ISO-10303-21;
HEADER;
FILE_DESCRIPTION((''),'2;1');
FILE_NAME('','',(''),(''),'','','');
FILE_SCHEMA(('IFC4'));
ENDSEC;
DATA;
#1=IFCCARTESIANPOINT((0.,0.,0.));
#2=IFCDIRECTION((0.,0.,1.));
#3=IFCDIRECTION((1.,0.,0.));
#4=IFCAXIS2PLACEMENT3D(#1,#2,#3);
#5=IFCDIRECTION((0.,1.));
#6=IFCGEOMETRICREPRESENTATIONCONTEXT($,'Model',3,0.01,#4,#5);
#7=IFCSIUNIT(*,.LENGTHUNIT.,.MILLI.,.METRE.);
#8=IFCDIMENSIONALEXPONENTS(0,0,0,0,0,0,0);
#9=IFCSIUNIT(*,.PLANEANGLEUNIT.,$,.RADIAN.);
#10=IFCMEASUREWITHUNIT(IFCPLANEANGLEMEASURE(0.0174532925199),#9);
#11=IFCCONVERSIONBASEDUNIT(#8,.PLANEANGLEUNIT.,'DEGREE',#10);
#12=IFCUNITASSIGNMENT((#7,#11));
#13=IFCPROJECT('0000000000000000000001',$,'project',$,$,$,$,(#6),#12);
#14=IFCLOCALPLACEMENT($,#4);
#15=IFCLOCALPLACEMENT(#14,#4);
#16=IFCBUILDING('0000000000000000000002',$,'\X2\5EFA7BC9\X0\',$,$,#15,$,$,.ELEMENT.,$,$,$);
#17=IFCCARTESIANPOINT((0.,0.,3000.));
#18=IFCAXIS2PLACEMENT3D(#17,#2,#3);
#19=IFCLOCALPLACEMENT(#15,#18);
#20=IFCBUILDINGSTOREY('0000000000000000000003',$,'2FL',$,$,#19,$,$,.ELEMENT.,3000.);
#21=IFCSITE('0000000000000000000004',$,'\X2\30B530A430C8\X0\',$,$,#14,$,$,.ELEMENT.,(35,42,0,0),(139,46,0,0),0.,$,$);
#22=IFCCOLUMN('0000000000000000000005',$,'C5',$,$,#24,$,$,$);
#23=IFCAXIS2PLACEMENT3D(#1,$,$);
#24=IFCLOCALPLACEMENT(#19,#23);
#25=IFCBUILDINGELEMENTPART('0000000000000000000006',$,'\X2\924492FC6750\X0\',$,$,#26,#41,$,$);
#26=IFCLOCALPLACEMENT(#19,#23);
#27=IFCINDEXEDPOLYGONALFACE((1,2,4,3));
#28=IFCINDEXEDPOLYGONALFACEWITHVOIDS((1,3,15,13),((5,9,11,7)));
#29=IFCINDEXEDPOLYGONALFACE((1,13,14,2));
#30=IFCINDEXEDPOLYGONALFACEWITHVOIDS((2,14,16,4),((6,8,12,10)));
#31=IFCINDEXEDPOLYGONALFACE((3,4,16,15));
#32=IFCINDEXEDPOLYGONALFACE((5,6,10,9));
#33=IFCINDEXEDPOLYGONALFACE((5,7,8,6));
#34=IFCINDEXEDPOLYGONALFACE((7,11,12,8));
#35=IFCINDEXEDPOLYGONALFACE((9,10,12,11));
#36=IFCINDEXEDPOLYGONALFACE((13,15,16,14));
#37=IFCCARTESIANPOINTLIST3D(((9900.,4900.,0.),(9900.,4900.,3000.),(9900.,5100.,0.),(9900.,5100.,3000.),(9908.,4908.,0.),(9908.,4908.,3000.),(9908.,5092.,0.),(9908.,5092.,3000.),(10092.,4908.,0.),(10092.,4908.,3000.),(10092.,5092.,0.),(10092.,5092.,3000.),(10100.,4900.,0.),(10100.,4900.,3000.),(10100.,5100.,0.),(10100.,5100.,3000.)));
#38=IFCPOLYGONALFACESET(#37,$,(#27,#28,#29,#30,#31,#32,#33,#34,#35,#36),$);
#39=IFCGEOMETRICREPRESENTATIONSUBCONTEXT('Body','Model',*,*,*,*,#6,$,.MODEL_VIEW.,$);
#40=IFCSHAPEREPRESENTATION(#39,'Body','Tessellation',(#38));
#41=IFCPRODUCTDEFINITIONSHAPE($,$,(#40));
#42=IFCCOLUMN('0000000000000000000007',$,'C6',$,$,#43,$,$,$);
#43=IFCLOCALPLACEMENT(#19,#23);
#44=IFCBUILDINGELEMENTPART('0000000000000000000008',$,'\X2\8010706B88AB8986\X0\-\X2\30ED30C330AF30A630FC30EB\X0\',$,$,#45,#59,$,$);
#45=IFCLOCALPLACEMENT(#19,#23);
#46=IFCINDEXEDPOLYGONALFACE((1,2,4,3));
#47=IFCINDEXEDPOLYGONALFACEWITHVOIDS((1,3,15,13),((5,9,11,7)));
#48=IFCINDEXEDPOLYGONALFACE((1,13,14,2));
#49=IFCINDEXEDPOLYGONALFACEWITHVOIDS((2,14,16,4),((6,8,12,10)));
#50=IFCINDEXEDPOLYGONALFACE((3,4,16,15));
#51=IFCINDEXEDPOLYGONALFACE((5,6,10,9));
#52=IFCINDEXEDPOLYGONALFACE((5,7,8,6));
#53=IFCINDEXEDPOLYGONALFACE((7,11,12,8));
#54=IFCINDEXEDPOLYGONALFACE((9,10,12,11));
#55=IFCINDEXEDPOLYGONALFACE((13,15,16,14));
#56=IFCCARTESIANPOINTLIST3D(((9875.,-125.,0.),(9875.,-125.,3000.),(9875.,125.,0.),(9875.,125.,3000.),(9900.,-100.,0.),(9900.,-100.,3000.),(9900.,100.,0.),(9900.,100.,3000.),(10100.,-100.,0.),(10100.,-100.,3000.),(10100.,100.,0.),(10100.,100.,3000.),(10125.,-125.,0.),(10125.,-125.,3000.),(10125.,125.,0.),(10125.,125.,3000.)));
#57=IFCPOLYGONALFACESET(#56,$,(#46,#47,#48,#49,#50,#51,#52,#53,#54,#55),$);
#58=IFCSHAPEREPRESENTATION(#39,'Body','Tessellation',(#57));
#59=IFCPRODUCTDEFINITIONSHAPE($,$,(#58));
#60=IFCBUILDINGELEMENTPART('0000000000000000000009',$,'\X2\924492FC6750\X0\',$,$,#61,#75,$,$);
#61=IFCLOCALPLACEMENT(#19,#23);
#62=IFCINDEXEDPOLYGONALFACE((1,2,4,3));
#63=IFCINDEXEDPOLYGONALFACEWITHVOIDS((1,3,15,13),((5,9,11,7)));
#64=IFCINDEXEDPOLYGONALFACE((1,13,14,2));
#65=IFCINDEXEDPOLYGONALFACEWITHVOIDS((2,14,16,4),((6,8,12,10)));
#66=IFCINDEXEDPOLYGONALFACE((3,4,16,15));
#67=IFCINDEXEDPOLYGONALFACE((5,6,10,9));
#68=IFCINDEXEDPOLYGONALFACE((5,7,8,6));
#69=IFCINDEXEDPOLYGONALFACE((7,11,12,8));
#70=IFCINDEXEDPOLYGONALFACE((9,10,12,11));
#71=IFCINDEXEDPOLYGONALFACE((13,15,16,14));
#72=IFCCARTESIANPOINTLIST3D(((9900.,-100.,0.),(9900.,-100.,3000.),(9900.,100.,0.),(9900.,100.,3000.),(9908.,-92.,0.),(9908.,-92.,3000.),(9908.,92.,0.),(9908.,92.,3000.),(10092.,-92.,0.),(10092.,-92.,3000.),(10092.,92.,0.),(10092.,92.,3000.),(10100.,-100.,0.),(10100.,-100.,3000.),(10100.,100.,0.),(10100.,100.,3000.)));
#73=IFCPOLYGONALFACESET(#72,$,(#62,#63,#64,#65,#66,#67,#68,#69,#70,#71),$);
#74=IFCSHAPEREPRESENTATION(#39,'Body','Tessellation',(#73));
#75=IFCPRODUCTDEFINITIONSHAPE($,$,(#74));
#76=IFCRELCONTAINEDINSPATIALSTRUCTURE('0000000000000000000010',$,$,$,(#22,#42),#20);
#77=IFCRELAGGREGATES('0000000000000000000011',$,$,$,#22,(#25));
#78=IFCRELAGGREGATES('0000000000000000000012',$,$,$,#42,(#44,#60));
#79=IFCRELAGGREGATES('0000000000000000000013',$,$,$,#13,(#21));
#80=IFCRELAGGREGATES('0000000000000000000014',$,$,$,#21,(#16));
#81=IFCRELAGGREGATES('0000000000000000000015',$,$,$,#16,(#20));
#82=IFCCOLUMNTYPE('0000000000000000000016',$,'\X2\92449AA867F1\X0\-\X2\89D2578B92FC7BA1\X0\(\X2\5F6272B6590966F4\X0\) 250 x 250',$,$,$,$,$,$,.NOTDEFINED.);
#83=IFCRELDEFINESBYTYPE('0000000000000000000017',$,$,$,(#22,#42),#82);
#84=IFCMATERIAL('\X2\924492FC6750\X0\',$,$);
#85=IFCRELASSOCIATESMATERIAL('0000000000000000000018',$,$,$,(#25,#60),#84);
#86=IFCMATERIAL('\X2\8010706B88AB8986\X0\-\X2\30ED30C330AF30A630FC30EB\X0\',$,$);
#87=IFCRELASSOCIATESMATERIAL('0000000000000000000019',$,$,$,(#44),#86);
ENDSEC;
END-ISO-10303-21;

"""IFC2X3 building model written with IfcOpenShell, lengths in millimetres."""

from ifc_helpers import new_model, entity, si_unit, converted_unit, direction, frame, origin_with_axes, place, context, subcontext, project, spatial, polyline, outline, extrude, material, type_object, element, aggregate, save


model = new_model("IFC2X3")

# Units and contexts
model_context = context("Model", 3, precision=0.01, world=origin_with_axes(), true_north=direction((0.0, 1.0)))
body_context = subcontext(model_context, "Body", "Model", "MODEL_VIEW")
ifc_project = project(units=[si_unit("LENGTHUNIT", "METRE", prefix="MILLI"), converted_unit("PLANEANGLEUNIT", "DEGREE", entity("IfcPlaneAngleMeasure", 0.0174532925199), si_unit("PLANEANGLEUNIT", "RADIAN"), dimensions=[0, 0, 0, 0, 0, 0, 0])], contexts=[model_context])

# Site, building, storey
site_placement = place(None, origin_with_axes())
site = spatial("IfcSite", under=ifc_project, at=site_placement, Name="サイト", CompositionType="ELEMENT", RefLatitude=(35, 42, 0, 0), RefLongitude=(139, 46, 0, 0), RefElevation=0.0)
building_placement = place(site_placement, origin_with_axes())
building = spatial("IfcBuilding", under=site, at=building_placement, Name="建築", CompositionType="ELEMENT")
storey_placement = place(building_placement, frame((0.0, 0.0, 3000.0), z_axis=(0.0, 0.0, 1.0), x_axis=(1.0, 0.0, 0.0)))
storey = spatial("IfcBuildingStorey", under=building, at=storey_placement, Name="2FL", CompositionType="ELEMENT", Elevation=3000.0)

# Shared definitions
ifc_material_1 = material(Name="耐火被覆-ロックウール")
ifc_material_2 = material(Name="鉄鋼材")

# Columns, building element parts
column_type_1 = type_object("IfcColumnType", Name="鉄骨柱-角型鋼管(形状変更) 250 x 250", PredefinedType="NOTDEFINED")
column_1_placement = place(storey_placement, frame((10000.0, 5000.0, 0.0), z_axis=(0.0, 0.0, 1.0), x_axis=(1.0, 0.0, 0.0)))
column_1 = element("IfcColumn", 1, at=column_1_placement, inside=storey, type_object=column_type_1, Name="C5")
building_element_part_1_placement = place(column_1_placement, origin_with_axes())
building_element_part_1 = element("IfcBuildingElementPart", 2, at=building_element_part_1_placement, material=ifc_material_2, Name="鉄鋼材", context=body_context, shape_type="SweptSolid", body=[
    extrude(outline(polyline([(-100.0, -100.0), (100.0, -100.0), (100.0, 100.0), (-100.0, 100.0), (-100.0, -100.0)]), holes=[polyline([(92.0, -92.0), (-92.0, -92.0), (-92.0, 92.0), (92.0, 92.0), (92.0, -92.0)])]), origin_with_axes(), (0.0, 0.0, 1.0), 3000.0),
])
aggregate(column_1, [building_element_part_1])
column_2_placement = place(storey_placement, frame((10000.0, 0.0, 0.0), z_axis=(0.0, 0.0, 1.0), x_axis=(1.0, 0.0, 0.0)))
column_2 = element("IfcColumn", 3, at=column_2_placement, inside=storey, type_object=column_type_1, Name="C6")
building_element_part_2_placement = place(column_2_placement, origin_with_axes())
building_element_part_2 = element("IfcBuildingElementPart", 4, at=building_element_part_2_placement, material=ifc_material_1, Name="耐火被覆-ロックウール", context=body_context, shape_type="SweptSolid", body=[
    extrude(outline(polyline([(-125.0, -125.0), (125.0, -125.0), (125.0, 125.0), (-125.0, 125.0), (-125.0, -125.0)]), holes=[polyline([(-100.0, 100.0), (100.0, 100.0), (100.0, -100.0), (-100.0, -100.0), (-100.0, 100.0)])]), origin_with_axes(), (0.0, 0.0, 1.0), 3000.0),
])
building_element_part_3_placement = place(column_2_placement, origin_with_axes())
building_element_part_3 = element("IfcBuildingElementPart", 5, at=building_element_part_3_placement, material=ifc_material_2, Name="鉄鋼材", context=body_context, shape_type="SweptSolid", body=[
    extrude(outline(polyline([(-100.0, -100.0), (100.0, -100.0), (100.0, 100.0), (-100.0, 100.0), (-100.0, -100.0)]), holes=[polyline([(92.0, -92.0), (-92.0, -92.0), (-92.0, 92.0), (92.0, 92.0), (92.0, -92.0)])]), origin_with_axes(), (0.0, 0.0, 1.0), 3000.0),
])
aggregate(column_2, [building_element_part_2, building_element_part_3])

save(model, "model.ifc")
